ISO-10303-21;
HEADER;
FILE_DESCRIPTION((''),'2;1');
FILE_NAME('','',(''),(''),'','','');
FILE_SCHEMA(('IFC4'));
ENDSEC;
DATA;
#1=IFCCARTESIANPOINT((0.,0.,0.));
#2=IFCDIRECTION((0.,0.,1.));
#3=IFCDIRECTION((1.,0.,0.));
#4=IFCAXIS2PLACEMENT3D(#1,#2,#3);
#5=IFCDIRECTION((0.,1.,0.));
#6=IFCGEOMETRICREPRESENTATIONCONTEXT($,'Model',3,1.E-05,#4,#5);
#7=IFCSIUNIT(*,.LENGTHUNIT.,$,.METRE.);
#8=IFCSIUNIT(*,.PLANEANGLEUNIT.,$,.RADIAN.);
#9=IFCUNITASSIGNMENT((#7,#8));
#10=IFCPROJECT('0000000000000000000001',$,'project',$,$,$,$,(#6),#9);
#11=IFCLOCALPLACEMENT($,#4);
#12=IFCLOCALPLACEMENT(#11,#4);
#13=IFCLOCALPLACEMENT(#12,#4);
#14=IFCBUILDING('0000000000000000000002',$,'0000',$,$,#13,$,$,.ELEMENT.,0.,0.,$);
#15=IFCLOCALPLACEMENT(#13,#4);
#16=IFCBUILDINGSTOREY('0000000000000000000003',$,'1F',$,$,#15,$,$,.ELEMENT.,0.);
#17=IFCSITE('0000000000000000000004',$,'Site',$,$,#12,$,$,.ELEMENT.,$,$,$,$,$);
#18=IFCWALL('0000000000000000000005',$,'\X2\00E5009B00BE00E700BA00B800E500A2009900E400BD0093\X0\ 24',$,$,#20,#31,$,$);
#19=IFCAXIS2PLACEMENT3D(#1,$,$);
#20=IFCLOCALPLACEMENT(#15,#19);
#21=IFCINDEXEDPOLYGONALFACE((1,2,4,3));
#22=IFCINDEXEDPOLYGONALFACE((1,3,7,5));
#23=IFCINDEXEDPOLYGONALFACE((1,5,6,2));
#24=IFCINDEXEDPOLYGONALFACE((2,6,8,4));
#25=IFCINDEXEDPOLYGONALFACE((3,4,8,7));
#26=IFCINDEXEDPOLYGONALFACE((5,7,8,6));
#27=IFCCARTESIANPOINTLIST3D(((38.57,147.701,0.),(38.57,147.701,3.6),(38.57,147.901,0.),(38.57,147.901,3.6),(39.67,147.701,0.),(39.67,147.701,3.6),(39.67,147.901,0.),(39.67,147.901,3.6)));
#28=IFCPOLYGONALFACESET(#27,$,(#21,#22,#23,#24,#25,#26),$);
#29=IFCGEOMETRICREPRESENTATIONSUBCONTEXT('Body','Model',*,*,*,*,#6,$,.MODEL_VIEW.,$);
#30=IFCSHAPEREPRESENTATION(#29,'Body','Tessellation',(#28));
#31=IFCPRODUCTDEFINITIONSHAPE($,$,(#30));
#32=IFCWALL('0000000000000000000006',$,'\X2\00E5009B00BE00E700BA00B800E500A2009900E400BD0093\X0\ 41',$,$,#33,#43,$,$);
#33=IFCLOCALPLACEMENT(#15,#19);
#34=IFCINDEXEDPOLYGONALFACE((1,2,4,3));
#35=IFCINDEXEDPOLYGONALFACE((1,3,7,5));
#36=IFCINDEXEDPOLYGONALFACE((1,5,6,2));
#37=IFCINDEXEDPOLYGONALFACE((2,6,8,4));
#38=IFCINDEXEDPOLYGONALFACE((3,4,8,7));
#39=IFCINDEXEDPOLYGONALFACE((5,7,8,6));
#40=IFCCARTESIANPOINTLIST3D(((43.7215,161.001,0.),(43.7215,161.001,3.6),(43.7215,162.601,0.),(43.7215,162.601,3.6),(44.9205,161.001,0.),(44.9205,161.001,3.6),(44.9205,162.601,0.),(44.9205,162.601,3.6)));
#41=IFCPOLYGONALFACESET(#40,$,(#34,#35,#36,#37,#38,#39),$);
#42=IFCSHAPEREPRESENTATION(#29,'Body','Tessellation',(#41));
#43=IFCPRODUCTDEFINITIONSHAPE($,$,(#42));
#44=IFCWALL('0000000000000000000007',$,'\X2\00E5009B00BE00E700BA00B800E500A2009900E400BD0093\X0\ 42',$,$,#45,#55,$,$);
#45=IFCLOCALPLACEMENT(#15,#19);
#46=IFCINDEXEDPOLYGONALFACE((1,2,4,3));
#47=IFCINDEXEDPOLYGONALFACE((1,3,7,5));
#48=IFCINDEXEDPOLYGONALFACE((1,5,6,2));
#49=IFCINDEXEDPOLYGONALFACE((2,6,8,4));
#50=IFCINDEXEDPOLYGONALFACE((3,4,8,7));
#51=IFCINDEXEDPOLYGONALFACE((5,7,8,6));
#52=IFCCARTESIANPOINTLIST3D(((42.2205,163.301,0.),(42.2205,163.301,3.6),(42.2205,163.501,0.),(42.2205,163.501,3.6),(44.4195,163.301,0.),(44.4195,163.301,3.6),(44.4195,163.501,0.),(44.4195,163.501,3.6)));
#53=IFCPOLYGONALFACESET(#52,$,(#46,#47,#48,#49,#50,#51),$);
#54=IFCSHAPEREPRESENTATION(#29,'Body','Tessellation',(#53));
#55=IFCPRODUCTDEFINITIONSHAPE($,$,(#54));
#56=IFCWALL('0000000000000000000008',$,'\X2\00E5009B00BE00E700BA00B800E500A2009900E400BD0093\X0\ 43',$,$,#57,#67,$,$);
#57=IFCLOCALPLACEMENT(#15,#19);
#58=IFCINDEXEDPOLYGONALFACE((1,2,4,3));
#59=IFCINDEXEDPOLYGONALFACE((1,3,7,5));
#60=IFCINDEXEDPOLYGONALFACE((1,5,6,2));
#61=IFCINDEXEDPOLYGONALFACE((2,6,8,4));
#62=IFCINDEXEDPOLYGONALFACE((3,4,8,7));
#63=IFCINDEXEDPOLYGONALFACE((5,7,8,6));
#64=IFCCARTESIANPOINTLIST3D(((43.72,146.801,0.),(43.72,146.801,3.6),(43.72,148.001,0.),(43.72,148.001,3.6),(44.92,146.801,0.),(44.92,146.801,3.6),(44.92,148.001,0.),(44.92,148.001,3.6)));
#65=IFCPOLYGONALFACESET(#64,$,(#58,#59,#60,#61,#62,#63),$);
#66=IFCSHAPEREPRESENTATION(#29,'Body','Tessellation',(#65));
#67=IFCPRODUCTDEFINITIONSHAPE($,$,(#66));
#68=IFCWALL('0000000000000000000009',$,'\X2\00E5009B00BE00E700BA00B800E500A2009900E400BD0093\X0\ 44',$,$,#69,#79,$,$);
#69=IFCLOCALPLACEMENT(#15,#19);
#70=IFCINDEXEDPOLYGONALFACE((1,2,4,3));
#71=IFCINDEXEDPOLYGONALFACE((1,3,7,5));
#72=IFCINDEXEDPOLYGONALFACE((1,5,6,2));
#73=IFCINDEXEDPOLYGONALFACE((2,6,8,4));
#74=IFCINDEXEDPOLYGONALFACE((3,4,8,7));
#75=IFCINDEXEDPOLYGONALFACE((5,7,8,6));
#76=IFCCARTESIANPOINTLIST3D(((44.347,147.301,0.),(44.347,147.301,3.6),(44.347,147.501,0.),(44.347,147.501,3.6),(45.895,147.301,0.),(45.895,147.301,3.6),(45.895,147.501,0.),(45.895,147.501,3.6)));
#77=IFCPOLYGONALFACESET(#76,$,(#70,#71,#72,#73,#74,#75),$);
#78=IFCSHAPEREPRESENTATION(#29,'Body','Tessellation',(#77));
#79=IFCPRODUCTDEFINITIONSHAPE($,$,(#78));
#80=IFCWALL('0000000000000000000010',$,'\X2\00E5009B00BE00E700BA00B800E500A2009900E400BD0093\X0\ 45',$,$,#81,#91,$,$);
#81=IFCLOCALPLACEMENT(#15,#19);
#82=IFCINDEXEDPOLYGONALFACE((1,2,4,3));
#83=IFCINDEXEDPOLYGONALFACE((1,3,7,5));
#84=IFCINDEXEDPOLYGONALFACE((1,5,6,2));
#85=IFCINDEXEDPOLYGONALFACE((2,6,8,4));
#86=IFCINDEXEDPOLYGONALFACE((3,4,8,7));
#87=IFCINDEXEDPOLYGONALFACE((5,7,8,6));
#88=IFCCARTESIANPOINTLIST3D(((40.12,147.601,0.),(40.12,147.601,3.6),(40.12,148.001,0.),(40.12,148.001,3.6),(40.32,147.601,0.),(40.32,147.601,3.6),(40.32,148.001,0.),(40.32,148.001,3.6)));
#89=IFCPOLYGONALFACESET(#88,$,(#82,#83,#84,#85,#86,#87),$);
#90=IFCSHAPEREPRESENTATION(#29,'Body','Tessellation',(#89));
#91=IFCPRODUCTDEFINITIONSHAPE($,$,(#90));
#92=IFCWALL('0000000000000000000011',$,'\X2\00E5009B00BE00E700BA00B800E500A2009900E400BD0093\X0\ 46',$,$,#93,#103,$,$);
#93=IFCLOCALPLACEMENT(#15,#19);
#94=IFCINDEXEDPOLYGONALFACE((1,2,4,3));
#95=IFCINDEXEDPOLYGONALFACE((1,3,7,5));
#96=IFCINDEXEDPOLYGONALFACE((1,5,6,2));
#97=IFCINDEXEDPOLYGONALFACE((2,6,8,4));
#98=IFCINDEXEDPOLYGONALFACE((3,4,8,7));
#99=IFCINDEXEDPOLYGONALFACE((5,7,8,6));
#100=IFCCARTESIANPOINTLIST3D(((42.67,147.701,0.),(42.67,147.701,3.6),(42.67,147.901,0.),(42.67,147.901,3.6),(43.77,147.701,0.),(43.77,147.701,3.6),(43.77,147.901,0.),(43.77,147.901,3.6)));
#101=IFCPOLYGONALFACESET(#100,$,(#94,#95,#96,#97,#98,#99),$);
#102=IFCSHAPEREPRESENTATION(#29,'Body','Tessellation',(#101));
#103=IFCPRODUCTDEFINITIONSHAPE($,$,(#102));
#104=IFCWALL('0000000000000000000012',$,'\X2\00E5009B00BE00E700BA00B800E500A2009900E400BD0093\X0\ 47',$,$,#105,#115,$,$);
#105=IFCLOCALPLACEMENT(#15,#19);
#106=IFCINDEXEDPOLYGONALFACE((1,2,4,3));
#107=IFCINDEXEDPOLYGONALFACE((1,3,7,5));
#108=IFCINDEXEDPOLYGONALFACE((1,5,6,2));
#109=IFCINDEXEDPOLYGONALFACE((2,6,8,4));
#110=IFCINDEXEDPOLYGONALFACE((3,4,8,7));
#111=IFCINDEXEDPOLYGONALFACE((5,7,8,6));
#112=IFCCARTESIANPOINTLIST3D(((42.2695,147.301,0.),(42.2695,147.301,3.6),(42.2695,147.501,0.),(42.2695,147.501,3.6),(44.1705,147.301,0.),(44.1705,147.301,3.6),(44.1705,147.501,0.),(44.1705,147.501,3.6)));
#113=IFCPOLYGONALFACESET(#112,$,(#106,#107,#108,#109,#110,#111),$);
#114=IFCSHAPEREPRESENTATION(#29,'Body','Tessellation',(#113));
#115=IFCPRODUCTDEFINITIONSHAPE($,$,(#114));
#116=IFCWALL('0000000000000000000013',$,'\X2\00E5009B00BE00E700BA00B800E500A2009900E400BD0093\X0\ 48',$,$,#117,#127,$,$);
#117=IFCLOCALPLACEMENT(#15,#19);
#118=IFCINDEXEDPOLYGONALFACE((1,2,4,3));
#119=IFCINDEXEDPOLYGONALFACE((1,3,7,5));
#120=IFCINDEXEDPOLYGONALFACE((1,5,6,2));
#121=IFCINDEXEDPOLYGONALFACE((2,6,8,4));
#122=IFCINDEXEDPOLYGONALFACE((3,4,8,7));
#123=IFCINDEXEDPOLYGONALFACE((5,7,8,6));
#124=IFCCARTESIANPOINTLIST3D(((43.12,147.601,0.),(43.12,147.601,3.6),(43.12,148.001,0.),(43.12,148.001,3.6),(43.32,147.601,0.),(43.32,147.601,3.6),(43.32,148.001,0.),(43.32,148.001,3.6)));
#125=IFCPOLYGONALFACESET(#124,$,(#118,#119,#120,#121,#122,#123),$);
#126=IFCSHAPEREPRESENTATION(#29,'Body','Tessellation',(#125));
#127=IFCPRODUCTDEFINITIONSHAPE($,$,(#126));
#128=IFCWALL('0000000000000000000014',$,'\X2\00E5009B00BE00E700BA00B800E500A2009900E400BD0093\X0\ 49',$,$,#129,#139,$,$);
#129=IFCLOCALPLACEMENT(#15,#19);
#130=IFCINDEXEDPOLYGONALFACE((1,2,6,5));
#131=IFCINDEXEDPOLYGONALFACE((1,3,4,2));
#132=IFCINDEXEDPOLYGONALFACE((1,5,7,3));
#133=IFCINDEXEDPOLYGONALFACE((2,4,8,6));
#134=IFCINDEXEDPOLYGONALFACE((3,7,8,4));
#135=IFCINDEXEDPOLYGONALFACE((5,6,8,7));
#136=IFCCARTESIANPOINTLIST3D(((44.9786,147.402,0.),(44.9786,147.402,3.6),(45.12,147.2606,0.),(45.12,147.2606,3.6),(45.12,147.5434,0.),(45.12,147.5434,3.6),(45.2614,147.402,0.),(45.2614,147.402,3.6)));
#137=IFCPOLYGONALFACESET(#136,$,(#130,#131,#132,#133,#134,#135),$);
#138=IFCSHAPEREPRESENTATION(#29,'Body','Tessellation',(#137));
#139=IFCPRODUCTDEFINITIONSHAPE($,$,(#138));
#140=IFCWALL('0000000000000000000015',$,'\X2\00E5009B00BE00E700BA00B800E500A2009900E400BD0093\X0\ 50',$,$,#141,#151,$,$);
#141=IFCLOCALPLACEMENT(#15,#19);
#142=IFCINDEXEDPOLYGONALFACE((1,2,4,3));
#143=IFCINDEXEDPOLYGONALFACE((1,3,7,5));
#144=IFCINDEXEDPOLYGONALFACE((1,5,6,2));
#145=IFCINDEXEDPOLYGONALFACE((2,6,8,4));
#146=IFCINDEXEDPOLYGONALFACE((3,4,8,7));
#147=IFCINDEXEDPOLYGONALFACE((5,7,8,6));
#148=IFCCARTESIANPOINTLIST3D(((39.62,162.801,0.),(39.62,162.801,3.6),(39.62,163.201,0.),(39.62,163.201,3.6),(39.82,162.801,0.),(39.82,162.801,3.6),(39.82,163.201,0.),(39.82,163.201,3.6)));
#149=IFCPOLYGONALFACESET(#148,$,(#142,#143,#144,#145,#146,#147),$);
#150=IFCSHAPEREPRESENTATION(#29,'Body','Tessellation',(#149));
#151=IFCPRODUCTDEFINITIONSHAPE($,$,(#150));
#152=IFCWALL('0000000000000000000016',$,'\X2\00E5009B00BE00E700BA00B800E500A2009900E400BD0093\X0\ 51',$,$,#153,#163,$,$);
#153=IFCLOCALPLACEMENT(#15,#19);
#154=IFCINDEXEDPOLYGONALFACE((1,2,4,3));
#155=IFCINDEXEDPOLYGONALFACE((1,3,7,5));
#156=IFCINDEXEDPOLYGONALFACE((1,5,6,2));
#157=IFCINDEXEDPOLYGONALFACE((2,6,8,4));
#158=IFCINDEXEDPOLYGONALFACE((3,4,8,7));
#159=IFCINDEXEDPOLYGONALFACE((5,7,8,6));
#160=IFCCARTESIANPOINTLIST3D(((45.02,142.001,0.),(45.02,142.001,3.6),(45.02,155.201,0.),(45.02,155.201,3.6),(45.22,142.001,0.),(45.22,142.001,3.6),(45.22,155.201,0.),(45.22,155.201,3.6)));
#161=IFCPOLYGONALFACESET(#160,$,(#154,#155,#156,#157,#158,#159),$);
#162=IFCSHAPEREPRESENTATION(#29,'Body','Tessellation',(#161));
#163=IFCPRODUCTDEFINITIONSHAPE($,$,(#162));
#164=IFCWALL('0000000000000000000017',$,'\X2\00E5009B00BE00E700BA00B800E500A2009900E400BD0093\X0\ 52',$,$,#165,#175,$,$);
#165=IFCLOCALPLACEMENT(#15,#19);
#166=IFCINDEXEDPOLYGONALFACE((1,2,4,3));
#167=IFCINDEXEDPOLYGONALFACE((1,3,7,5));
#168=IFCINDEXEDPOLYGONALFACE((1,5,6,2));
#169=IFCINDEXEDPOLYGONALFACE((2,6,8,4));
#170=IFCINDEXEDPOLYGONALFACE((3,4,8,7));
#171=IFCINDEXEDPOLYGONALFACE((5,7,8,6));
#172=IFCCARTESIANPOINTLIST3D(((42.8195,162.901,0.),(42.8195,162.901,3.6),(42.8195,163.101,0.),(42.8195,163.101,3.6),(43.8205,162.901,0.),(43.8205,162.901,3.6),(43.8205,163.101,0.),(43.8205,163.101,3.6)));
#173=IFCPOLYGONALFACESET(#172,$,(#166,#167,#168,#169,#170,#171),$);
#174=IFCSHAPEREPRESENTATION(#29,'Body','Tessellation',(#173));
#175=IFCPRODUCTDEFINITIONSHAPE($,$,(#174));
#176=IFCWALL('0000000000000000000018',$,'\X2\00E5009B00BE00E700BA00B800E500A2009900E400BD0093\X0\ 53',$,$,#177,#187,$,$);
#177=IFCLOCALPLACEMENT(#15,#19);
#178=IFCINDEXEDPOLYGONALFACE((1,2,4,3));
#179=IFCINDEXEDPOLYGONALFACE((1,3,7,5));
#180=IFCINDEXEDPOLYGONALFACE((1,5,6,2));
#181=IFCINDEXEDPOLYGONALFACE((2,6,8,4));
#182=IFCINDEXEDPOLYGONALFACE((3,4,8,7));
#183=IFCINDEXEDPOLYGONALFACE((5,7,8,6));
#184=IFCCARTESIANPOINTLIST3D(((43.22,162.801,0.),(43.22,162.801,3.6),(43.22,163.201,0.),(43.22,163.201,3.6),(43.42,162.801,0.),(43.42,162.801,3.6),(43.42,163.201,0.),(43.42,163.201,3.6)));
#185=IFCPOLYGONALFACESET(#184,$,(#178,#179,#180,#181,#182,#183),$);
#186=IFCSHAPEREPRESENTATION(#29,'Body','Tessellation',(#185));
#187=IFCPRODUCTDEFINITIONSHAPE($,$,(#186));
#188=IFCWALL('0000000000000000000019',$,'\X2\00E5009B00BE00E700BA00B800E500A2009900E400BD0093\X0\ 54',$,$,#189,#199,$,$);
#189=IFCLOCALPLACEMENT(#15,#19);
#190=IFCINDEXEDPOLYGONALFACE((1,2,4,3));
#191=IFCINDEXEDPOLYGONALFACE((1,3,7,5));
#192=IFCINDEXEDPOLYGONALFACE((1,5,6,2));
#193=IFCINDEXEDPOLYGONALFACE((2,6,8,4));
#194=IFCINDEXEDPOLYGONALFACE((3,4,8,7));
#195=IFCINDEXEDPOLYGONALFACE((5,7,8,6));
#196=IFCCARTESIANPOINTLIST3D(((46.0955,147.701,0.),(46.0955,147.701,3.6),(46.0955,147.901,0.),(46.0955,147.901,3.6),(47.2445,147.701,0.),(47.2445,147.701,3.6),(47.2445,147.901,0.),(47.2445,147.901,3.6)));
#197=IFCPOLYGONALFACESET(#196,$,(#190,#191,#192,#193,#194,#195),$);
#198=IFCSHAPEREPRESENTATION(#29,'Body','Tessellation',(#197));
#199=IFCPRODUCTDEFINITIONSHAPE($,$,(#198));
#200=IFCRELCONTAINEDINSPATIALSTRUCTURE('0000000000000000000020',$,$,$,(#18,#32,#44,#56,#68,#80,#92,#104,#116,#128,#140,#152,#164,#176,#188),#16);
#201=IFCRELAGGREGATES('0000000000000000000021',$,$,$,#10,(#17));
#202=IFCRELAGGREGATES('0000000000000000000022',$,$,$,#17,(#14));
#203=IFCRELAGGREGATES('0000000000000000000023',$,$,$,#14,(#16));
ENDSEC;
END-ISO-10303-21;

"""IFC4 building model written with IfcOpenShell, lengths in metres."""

from ifc_helpers import new_model, si_unit, direction, frame, frame_2d, origin_with_axes, place, context, subcontext, project, spatial, rectangle, extrude, element, save


model = new_model("IFC4")

# Units and contexts
model_context = context("Model", 3, precision=1e-05, world=origin_with_axes(), true_north=direction((0.0, 1.0, 0.0)))
body_context = subcontext(model_context, "Body", "Model", "MODEL_VIEW")
ifc_project = project(units=[si_unit("LENGTHUNIT", "METRE"), si_unit("PLANEANGLEUNIT", "RADIAN")], contexts=[model_context])

# Site, building, storey
placement = place(None, origin_with_axes())
site_placement = place(placement, origin_with_axes())
site = spatial("IfcSite", under=ifc_project, at=site_placement, Name="Site", CompositionType="ELEMENT")
building_placement = place(site_placement, origin_with_axes())
building = spatial("IfcBuilding", under=site, at=building_placement, Name="0000", CompositionType="ELEMENT", ElevationOfRefHeight=0.0, ElevationOfTerrain=0.0)
storey_placement = place(building_placement, origin_with_axes())
storey = spatial("IfcBuildingStorey", under=building, at=storey_placement, Name="1F", CompositionType="ELEMENT", Elevation=0.0)

# Walls
wall_1_placement = place(storey_placement, frame((39.12, 147.801, 0.0), z_axis=(0.0, 0.0, 1.0), x_axis=(1.0, 0.0, 0.0)))
element("IfcWall", 1, at=wall_1_placement, inside=storey, Name="å\u009b¾çº¸å¢\u0099ä½\u0093 24", context=body_context, shape_type="SweptSolid", body=[
    extrude(rectangle(XDim=1.1, YDim=0.2, at=frame_2d((0.0, 0.0), x_axis=(1.0, 0.0, 0.0))), frame((0.0, 0.0, 0.0), z_axis=(0.0, 0.0, 1.0)), (0.0, 0.0, 1.0), 3.6),
])
wall_2_placement = place(storey_placement, frame((44.321, 161.801, 0.0), z_axis=(0.0, 0.0, 1.0), x_axis=(1.0, 0.0, 0.0)))
element("IfcWall", 2, at=wall_2_placement, inside=storey, Name="å\u009b¾çº¸å¢\u0099ä½\u0093 41", context=body_context, shape_type="SweptSolid", body=[
    extrude(rectangle(XDim=1.199, YDim=1.6, at=frame_2d((0.0, 0.0), x_axis=(1.0, 0.0, 0.0))), frame((0.0, 0.0, 0.0), z_axis=(0.0, 0.0, 1.0)), (0.0, 0.0, 1.0), 3.6),
])
wall_3_placement = place(storey_placement, frame((43.32, 163.401, 0.0), z_axis=(0.0, 0.0, 1.0), x_axis=(1.0, 0.0, 0.0)))
element("IfcWall", 3, at=wall_3_placement, inside=storey, Name="å\u009b¾çº¸å¢\u0099ä½\u0093 42", context=body_context, shape_type="SweptSolid", body=[
    extrude(rectangle(XDim=2.199, YDim=0.2, at=frame_2d((0.0, 0.0), x_axis=(1.0, 0.0, 0.0))), frame((0.0, 0.0, 0.0), z_axis=(0.0, 0.0, 1.0)), (0.0, 0.0, 1.0), 3.6),
])
wall_4_placement = place(storey_placement, frame((44.32, 147.401, 0.0), z_axis=(0.0, 0.0, 1.0), x_axis=(1.0, 0.0, 0.0)))
element("IfcWall", 4, at=wall_4_placement, inside=storey, Name="å\u009b¾çº¸å¢\u0099ä½\u0093 43", context=body_context, shape_type="SweptSolid", body=[
    extrude(rectangle(XDim=1.2, YDim=1.2, at=frame_2d((0.0, 0.0), x_axis=(1.0, 0.0, 0.0))), frame((0.0, 0.0, 0.0), z_axis=(0.0, 0.0, 1.0)), (0.0, 0.0, 1.0), 3.6),
])
wall_5_placement = place(storey_placement, frame((45.121, 147.401, 0.0), z_axis=(0.0, 0.0, 1.0), x_axis=(1.0, 0.0, 0.0)))
element("IfcWall", 5, at=wall_5_placement, inside=storey, Name="å\u009b¾çº¸å¢\u0099ä½\u0093 44", context=body_context, shape_type="SweptSolid", body=[
    extrude(rectangle(XDim=1.548, YDim=0.2, at=frame_2d((0.0, 0.0), x_axis=(1.0, 0.0, 0.0))), frame((0.0, 0.0, 0.0), z_axis=(0.0, 0.0, 1.0)), (0.0, 0.0, 1.0), 3.6),
])
wall_6_placement = place(storey_placement, frame((40.22, 147.801, 0.0), z_axis=(0.0, 0.0, 1.0), x_axis=(0.0, -1.0, 0.0)))
element("IfcWall", 6, at=wall_6_placement, inside=storey, Name="å\u009b¾çº¸å¢\u0099ä½\u0093 45", context=body_context, shape_type="SweptSolid", body=[
    extrude(rectangle(XDim=0.4, YDim=0.2, at=frame_2d((0.0, 0.0), x_axis=(1.0, 0.0, 0.0))), frame((0.0, 0.0, 0.0), z_axis=(0.0, 0.0, 1.0)), (0.0, 0.0, 1.0), 3.6),
])
wall_7_placement = place(storey_placement, frame((43.22, 147.801, 0.0), z_axis=(0.0, 0.0, 1.0), x_axis=(1.0, 0.0, 0.0)))
element("IfcWall", 7, at=wall_7_placement, inside=storey, Name="å\u009b¾çº¸å¢\u0099ä½\u0093 46", context=body_context, shape_type="SweptSolid", body=[
    extrude(rectangle(XDim=1.1, YDim=0.2, at=frame_2d((0.0, 0.0), x_axis=(1.0, 0.0, 0.0))), frame((0.0, 0.0, 0.0), z_axis=(0.0, 0.0, 1.0)), (0.0, 0.0, 1.0), 3.6),
])
wall_8_placement = place(storey_placement, frame((43.22, 147.401, 0.0), z_axis=(0.0, 0.0, 1.0), x_axis=(1.0, 0.0, 0.0)))
element("IfcWall", 8, at=wall_8_placement, inside=storey, Name="å\u009b¾çº¸å¢\u0099ä½\u0093 47", context=body_context, shape_type="SweptSolid", body=[
    extrude(rectangle(XDim=1.901, YDim=0.2, at=frame_2d((0.0, 0.0), x_axis=(1.0, 0.0, 0.0))), frame((0.0, 0.0, 0.0), z_axis=(0.0, 0.0, 1.0)), (0.0, 0.0, 1.0), 3.6),
])
wall_9_placement = place(storey_placement, frame((43.22, 147.801, 0.0), z_axis=(0.0, 0.0, 1.0), x_axis=(0.0, -1.0, 0.0)))
element("IfcWall", 9, at=wall_9_placement, inside=storey, Name="å\u009b¾çº¸å¢\u0099ä½\u0093 48", context=body_context, shape_type="SweptSolid", body=[
    extrude(rectangle(XDim=0.4, YDim=0.2, at=frame_2d((0.0, 0.0), x_axis=(1.0, 0.0, 0.0))), frame((0.0, 0.0, 0.0), z_axis=(0.0, 0.0, 1.0)), (0.0, 0.0, 1.0), 3.6),
])
wall_10_placement = place(storey_placement, frame((45.12, 147.402, 0.0), z_axis=(0.0, 0.0, 1.0), x_axis=(0.707107, -0.707107, 0.0)))
element("IfcWall", 10, at=wall_10_placement, inside=storey, Name="å\u009b¾çº¸å¢\u0099ä½\u0093 49", context=body_context, shape_type="SweptSolid", body=[
    extrude(rectangle(XDim=0.2, YDim=0.2, at=frame_2d((0.0, 0.0), x_axis=(1.0, 0.0, 0.0))), frame((0.0, 0.0, 0.0), z_axis=(0.0, 0.0, 1.0)), (0.0, 0.0, 1.0), 3.6),
])
wall_11_placement = place(storey_placement, frame((39.72, 163.001, 0.0), z_axis=(0.0, 0.0, 1.0), x_axis=(0.0, 1.0, 0.0)))
element("IfcWall", 11, at=wall_11_placement, inside=storey, Name="å\u009b¾çº¸å¢\u0099ä½\u0093 50", context=body_context, shape_type="SweptSolid", body=[
    extrude(rectangle(XDim=0.4, YDim=0.2, at=frame_2d((0.0, 0.0), x_axis=(1.0, 0.0, 0.0))), frame((0.0, 0.0, 0.0), z_axis=(0.0, 0.0, 1.0)), (0.0, 0.0, 1.0), 3.6),
])
wall_12_placement = place(storey_placement, frame((45.12, 148.601, 0.0), z_axis=(0.0, 0.0, 1.0), x_axis=(0.0, 1.0, 0.0)))
element("IfcWall", 12, at=wall_12_placement, inside=storey, Name="å\u009b¾çº¸å¢\u0099ä½\u0093 51", context=body_context, shape_type="SweptSolid", body=[
    extrude(rectangle(XDim=13.2, YDim=0.2, at=frame_2d((0.0, 0.0), x_axis=(1.0, 0.0, 0.0))), frame((0.0, 0.0, 0.0), z_axis=(0.0, 0.0, 1.0)), (0.0, 0.0, 1.0), 3.6),
])
wall_13_placement = place(storey_placement, frame((43.32, 163.001, 0.0), z_axis=(0.0, 0.0, 1.0), x_axis=(1.0, 0.0, 0.0)))
element("IfcWall", 13, at=wall_13_placement, inside=storey, Name="å\u009b¾çº¸å¢\u0099ä½\u0093 52", context=body_context, shape_type="SweptSolid", body=[
    extrude(rectangle(XDim=1.001, YDim=0.2, at=frame_2d((0.0, 0.0), x_axis=(1.0, 0.0, 0.0))), frame((0.0, 0.0, 0.0), z_axis=(0.0, 0.0, 1.0)), (0.0, 0.0, 1.0), 3.6),
])
wall_14_placement = place(storey_placement, frame((43.32, 163.001, 0.0), z_axis=(0.0, 0.0, 1.0), x_axis=(0.0, 1.0, 0.0)))
element("IfcWall", 14, at=wall_14_placement, inside=storey, Name="å\u009b¾çº¸å¢\u0099ä½\u0093 53", context=body_context, shape_type="SweptSolid", body=[
    extrude(rectangle(XDim=0.4, YDim=0.2, at=frame_2d((0.0, 0.0), x_axis=(1.0, 0.0, 0.0))), frame((0.0, 0.0, 0.0), z_axis=(0.0, 0.0, 1.0)), (0.0, 0.0, 1.0), 3.6),
])
wall_15_placement = place(storey_placement, frame((46.67, 147.801, 0.0), z_axis=(0.0, 0.0, 1.0), x_axis=(-1.0, 0.0, 0.0)))
element("IfcWall", 15, at=wall_15_placement, inside=storey, Name="å\u009b¾çº¸å¢\u0099ä½\u0093 54", context=body_context, shape_type="SweptSolid", body=[
    extrude(rectangle(XDim=1.149, YDim=0.2, at=frame_2d((0.0, 0.0), x_axis=(1.0, 0.0, 0.0))), frame((0.0, 0.0, 0.0), z_axis=(0.0, 0.0, 1.0)), (0.0, 0.0, 1.0), 3.6),
])

save(model, "model.ifc")
